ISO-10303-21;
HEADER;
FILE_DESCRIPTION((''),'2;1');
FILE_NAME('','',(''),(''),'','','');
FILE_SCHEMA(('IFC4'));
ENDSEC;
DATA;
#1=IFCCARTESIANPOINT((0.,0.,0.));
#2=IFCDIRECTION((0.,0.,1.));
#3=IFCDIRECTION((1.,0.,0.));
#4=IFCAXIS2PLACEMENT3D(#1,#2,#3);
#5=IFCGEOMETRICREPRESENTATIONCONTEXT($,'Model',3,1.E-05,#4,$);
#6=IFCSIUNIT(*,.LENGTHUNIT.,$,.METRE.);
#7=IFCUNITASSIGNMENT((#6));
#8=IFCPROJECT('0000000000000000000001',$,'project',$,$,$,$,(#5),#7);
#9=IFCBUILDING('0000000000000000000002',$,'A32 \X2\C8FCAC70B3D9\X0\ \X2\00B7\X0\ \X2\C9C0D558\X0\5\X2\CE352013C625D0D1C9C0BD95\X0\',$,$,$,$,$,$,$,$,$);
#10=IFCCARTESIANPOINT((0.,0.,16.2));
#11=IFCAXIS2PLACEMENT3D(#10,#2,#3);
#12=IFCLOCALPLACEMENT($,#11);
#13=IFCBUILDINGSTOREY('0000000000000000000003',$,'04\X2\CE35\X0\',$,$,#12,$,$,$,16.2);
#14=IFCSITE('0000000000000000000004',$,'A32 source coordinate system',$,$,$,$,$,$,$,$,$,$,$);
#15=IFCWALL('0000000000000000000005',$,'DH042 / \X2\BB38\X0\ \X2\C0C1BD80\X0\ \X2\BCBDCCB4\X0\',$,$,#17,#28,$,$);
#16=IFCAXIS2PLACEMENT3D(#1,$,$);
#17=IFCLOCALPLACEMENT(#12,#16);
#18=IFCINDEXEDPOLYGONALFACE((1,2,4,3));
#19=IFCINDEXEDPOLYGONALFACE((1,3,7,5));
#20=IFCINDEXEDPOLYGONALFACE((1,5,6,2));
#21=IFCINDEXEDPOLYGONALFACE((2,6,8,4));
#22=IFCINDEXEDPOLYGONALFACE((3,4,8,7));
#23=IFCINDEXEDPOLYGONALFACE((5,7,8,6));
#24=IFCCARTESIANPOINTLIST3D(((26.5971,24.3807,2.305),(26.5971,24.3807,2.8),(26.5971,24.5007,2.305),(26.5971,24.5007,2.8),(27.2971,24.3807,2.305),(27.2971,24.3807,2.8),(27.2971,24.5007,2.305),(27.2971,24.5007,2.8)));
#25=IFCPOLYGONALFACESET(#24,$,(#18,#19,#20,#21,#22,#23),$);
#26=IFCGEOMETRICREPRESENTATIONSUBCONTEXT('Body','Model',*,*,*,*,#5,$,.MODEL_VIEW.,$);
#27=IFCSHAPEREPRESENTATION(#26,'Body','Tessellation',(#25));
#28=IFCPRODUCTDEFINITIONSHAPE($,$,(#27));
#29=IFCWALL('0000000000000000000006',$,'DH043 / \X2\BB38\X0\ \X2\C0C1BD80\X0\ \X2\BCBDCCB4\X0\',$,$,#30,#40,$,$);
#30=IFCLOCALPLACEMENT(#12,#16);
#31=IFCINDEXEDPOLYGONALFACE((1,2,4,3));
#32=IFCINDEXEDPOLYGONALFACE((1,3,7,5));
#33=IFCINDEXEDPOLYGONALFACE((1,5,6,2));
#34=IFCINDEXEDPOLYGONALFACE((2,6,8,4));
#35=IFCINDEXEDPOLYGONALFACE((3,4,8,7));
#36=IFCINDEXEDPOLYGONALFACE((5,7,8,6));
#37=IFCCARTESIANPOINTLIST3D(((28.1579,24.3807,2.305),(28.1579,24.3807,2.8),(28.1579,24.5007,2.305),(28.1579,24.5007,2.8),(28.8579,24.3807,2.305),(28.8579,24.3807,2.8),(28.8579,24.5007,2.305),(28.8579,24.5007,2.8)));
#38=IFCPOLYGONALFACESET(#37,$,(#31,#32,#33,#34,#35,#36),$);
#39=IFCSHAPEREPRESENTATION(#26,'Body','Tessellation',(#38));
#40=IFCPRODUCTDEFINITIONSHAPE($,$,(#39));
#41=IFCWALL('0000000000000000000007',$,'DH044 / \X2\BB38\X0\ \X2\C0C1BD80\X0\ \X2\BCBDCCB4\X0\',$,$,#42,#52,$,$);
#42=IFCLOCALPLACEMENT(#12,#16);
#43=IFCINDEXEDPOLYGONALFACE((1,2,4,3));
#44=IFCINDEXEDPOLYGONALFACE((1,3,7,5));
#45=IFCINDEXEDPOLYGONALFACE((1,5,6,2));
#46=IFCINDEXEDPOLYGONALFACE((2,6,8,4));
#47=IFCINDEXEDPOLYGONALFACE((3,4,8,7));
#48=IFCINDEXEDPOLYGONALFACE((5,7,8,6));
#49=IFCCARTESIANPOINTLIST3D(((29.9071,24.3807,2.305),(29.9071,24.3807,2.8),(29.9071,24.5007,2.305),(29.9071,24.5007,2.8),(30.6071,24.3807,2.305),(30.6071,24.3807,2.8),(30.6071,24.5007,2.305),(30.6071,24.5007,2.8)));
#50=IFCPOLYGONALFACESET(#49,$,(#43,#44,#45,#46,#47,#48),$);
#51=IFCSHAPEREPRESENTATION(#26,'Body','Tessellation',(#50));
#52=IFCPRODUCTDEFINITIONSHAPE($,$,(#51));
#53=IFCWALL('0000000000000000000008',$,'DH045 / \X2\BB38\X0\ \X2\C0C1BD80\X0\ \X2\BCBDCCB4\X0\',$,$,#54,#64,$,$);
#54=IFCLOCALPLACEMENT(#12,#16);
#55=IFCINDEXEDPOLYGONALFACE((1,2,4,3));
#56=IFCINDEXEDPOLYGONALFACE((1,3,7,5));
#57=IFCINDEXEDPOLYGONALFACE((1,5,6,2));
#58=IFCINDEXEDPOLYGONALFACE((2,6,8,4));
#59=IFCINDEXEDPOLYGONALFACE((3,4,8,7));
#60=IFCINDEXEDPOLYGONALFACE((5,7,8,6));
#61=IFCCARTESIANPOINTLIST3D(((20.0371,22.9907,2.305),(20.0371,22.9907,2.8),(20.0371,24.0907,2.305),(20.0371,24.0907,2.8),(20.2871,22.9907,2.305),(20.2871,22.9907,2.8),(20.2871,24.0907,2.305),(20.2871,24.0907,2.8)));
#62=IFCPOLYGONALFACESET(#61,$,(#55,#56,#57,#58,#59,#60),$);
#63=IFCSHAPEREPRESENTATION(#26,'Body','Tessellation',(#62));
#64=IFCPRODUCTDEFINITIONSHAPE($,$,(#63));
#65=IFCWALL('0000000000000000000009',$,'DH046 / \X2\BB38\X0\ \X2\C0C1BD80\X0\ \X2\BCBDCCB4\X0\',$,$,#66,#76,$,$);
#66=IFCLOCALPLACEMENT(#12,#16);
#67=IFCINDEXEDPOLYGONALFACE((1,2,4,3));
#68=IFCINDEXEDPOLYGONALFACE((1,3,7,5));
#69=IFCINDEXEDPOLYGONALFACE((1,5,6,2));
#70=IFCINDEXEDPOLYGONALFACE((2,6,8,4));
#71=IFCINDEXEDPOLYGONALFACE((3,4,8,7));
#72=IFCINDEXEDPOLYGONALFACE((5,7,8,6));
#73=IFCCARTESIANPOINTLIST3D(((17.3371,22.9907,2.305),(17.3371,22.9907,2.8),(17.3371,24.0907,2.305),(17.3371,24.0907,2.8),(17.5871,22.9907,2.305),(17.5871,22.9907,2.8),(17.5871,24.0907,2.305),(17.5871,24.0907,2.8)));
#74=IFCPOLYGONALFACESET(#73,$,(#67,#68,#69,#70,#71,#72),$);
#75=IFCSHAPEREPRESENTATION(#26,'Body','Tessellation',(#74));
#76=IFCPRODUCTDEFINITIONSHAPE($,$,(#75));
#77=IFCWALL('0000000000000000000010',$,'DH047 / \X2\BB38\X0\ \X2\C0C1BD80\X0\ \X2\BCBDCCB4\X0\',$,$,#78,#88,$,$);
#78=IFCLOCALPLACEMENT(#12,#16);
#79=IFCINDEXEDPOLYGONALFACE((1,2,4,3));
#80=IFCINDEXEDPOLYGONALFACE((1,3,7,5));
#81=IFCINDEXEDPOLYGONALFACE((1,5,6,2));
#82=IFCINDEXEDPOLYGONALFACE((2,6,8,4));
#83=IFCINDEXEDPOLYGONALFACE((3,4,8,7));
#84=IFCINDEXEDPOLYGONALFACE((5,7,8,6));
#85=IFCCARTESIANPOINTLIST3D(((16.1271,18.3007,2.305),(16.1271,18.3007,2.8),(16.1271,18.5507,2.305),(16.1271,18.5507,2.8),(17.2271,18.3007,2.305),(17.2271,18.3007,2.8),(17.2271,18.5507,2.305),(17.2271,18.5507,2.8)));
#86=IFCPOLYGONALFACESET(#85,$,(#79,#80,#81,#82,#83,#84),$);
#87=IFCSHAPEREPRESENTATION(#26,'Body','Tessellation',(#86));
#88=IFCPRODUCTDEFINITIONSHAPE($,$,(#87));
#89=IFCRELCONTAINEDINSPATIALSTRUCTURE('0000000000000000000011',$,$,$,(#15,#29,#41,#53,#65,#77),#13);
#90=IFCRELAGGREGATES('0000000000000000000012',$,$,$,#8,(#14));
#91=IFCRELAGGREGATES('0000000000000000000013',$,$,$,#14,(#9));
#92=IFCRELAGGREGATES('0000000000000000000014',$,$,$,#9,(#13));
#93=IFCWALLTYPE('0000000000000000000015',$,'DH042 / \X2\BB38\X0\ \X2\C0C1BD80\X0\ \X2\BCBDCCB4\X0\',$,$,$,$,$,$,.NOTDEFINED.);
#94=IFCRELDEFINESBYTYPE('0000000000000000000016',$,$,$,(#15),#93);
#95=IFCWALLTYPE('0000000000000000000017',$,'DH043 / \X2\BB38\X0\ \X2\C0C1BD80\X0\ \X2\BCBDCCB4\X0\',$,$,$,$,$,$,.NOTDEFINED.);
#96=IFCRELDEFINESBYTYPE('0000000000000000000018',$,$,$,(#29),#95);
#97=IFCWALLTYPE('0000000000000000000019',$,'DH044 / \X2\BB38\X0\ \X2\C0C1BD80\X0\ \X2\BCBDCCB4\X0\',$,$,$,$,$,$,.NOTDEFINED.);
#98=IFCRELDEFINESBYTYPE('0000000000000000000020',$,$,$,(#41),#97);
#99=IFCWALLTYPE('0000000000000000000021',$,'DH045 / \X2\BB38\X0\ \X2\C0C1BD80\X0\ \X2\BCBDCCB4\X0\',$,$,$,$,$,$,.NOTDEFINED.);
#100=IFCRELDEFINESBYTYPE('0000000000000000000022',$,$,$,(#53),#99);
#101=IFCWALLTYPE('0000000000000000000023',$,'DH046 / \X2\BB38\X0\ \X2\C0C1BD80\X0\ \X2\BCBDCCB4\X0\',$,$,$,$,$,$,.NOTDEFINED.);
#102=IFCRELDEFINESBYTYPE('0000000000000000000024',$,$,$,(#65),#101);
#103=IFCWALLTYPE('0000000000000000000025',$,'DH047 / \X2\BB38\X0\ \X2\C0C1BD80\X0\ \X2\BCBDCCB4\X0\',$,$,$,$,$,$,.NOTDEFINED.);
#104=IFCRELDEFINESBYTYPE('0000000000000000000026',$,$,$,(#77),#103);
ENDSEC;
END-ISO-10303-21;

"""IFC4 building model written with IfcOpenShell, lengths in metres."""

from ifc_helpers import new_model, si_unit, frame, origin, origin_with_axes, place, context, subcontext, project, spatial, polyline, outline, extrude, source, transform, mapped, type_object, type_shapes, element, save


model = new_model("IFC4")

# Units and contexts
model_context = context("Model", 3, precision=1e-05, world=origin_with_axes())
body_context = subcontext(model_context, "Body", "Model", "MODEL_VIEW")
ifc_project = project(units=[si_unit("LENGTHUNIT", "METRE")], contexts=[model_context])

# Site, building, storey
site = spatial("IfcSite", under=ifc_project, Name="A32 source coordinate system")
building = spatial("IfcBuilding", under=site, Name="A32 주거동 · 지하5층–옥탑지붕")
storey_placement = place(None, frame((0.0, 0.0, 16.2), z_axis=(0.0, 0.0, 1.0), x_axis=(1.0, 0.0, 0.0)))
storey = spatial("IfcBuildingStorey", under=building, at=storey_placement, Name="04층", Elevation=16.2)

# Walls
wall_type_1 = type_object("IfcWallType", Name="DH042 / 문 상부 벽체", PredefinedType="NOTDEFINED")
shared_shape_1 = source(origin(), body_context, "Body", "SweptSolid", [
    extrude(outline(polyline([(27.2971, 24.3807), (26.5971, 24.3807), (26.5971, 24.5007), (27.2971, 24.5007), (27.2971, 24.3807)])), frame((0.0, 0.0, 2.305)), (0.0, 0.0, 1.0), 0.495),
])
type_shapes(wall_type_1, [shared_shape_1])
wall_1_placement = place(storey_placement, origin_with_axes())
element("IfcWall", 1, at=wall_1_placement, inside=storey, type_object=wall_type_1, Name="DH042 / 문 상부 벽체", context=body_context, shape_type="MappedRepresentation", body=[
    mapped(shared_shape_1, transform((0.0, 0.0, 0.0), scale=1.0)),
])
wall_type_2 = type_object("IfcWallType", Name="DH043 / 문 상부 벽체", PredefinedType="NOTDEFINED")
shared_shape_2 = source(origin(), body_context, "Body", "SweptSolid", [
    extrude(outline(polyline([(28.8579, 24.3807), (28.1579, 24.3807), (28.1579, 24.5007), (28.8579, 24.5007), (28.8579, 24.3807)])), frame((0.0, 0.0, 2.305)), (0.0, 0.0, 1.0), 0.495),
])
type_shapes(wall_type_2, [shared_shape_2])
wall_2_placement = place(storey_placement, origin_with_axes())
element("IfcWall", 2, at=wall_2_placement, inside=storey, type_object=wall_type_2, Name="DH043 / 문 상부 벽체", context=body_context, shape_type="MappedRepresentation", body=[
    mapped(shared_shape_2, transform((0.0, 0.0, 0.0), scale=1.0)),
])
wall_type_3 = type_object("IfcWallType", Name="DH044 / 문 상부 벽체", PredefinedType="NOTDEFINED")
shared_shape_3 = source(origin(), body_context, "Body", "SweptSolid", [
    extrude(outline(polyline([(30.6071, 24.3807), (29.9071, 24.3807), (29.9071, 24.5007), (30.6071, 24.5007), (30.6071, 24.3807)])), frame((0.0, 0.0, 2.305)), (0.0, 0.0, 1.0), 0.495),
])
type_shapes(wall_type_3, [shared_shape_3])
wall_3_placement = place(storey_placement, origin_with_axes())
element("IfcWall", 3, at=wall_3_placement, inside=storey, type_object=wall_type_3, Name="DH044 / 문 상부 벽체", context=body_context, shape_type="MappedRepresentation", body=[
    mapped(shared_shape_3, transform((0.0, 0.0, 0.0), scale=1.0)),
])
wall_type_4 = type_object("IfcWallType", Name="DH045 / 문 상부 벽체", PredefinedType="NOTDEFINED")
shared_shape_4 = source(origin(), body_context, "Body", "SweptSolid", [
    extrude(outline(polyline([(20.2871, 22.9907), (20.0371, 22.9907), (20.0371, 24.0907), (20.2871, 24.0907), (20.2871, 22.9907)])), frame((0.0, 0.0, 2.305)), (0.0, 0.0, 1.0), 0.495),
])
type_shapes(wall_type_4, [shared_shape_4])
wall_4_placement = place(storey_placement, origin_with_axes())
element("IfcWall", 4, at=wall_4_placement, inside=storey, type_object=wall_type_4, Name="DH045 / 문 상부 벽체", context=body_context, shape_type="MappedRepresentation", body=[
    mapped(shared_shape_4, transform((0.0, 0.0, 0.0), scale=1.0)),
])
wall_type_5 = type_object("IfcWallType", Name="DH046 / 문 상부 벽체", PredefinedType="NOTDEFINED")
shared_shape_5 = source(origin(), body_context, "Body", "SweptSolid", [
    extrude(outline(polyline([(17.5871, 22.9907), (17.3371, 22.9907), (17.3371, 24.0907), (17.5871, 24.0907), (17.5871, 22.9907)])), frame((0.0, 0.0, 2.305)), (0.0, 0.0, 1.0), 0.495),
])
type_shapes(wall_type_5, [shared_shape_5])
wall_5_placement = place(storey_placement, origin_with_axes())
element("IfcWall", 5, at=wall_5_placement, inside=storey, type_object=wall_type_5, Name="DH046 / 문 상부 벽체", context=body_context, shape_type="MappedRepresentation", body=[
    mapped(shared_shape_5, transform((0.0, 0.0, 0.0), scale=1.0)),
])
wall_type_6 = type_object("IfcWallType", Name="DH047 / 문 상부 벽체", PredefinedType="NOTDEFINED")
shared_shape_6 = source(origin(), body_context, "Body", "SweptSolid", [
    extrude(outline(polyline([(17.2271, 18.3007), (16.1271, 18.3007), (16.1271, 18.5507), (17.2271, 18.5507), (17.2271, 18.3007)])), frame((0.0, 0.0, 2.305)), (0.0, 0.0, 1.0), 0.495),
])
type_shapes(wall_type_6, [shared_shape_6])
wall_6_placement = place(storey_placement, origin_with_axes())
element("IfcWall", 6, at=wall_6_placement, inside=storey, type_object=wall_type_6, Name="DH047 / 문 상부 벽체", context=body_context, shape_type="MappedRepresentation", body=[
    mapped(shared_shape_6, transform((0.0, 0.0, 0.0), scale=1.0)),
])

save(model, "model.ifc")
